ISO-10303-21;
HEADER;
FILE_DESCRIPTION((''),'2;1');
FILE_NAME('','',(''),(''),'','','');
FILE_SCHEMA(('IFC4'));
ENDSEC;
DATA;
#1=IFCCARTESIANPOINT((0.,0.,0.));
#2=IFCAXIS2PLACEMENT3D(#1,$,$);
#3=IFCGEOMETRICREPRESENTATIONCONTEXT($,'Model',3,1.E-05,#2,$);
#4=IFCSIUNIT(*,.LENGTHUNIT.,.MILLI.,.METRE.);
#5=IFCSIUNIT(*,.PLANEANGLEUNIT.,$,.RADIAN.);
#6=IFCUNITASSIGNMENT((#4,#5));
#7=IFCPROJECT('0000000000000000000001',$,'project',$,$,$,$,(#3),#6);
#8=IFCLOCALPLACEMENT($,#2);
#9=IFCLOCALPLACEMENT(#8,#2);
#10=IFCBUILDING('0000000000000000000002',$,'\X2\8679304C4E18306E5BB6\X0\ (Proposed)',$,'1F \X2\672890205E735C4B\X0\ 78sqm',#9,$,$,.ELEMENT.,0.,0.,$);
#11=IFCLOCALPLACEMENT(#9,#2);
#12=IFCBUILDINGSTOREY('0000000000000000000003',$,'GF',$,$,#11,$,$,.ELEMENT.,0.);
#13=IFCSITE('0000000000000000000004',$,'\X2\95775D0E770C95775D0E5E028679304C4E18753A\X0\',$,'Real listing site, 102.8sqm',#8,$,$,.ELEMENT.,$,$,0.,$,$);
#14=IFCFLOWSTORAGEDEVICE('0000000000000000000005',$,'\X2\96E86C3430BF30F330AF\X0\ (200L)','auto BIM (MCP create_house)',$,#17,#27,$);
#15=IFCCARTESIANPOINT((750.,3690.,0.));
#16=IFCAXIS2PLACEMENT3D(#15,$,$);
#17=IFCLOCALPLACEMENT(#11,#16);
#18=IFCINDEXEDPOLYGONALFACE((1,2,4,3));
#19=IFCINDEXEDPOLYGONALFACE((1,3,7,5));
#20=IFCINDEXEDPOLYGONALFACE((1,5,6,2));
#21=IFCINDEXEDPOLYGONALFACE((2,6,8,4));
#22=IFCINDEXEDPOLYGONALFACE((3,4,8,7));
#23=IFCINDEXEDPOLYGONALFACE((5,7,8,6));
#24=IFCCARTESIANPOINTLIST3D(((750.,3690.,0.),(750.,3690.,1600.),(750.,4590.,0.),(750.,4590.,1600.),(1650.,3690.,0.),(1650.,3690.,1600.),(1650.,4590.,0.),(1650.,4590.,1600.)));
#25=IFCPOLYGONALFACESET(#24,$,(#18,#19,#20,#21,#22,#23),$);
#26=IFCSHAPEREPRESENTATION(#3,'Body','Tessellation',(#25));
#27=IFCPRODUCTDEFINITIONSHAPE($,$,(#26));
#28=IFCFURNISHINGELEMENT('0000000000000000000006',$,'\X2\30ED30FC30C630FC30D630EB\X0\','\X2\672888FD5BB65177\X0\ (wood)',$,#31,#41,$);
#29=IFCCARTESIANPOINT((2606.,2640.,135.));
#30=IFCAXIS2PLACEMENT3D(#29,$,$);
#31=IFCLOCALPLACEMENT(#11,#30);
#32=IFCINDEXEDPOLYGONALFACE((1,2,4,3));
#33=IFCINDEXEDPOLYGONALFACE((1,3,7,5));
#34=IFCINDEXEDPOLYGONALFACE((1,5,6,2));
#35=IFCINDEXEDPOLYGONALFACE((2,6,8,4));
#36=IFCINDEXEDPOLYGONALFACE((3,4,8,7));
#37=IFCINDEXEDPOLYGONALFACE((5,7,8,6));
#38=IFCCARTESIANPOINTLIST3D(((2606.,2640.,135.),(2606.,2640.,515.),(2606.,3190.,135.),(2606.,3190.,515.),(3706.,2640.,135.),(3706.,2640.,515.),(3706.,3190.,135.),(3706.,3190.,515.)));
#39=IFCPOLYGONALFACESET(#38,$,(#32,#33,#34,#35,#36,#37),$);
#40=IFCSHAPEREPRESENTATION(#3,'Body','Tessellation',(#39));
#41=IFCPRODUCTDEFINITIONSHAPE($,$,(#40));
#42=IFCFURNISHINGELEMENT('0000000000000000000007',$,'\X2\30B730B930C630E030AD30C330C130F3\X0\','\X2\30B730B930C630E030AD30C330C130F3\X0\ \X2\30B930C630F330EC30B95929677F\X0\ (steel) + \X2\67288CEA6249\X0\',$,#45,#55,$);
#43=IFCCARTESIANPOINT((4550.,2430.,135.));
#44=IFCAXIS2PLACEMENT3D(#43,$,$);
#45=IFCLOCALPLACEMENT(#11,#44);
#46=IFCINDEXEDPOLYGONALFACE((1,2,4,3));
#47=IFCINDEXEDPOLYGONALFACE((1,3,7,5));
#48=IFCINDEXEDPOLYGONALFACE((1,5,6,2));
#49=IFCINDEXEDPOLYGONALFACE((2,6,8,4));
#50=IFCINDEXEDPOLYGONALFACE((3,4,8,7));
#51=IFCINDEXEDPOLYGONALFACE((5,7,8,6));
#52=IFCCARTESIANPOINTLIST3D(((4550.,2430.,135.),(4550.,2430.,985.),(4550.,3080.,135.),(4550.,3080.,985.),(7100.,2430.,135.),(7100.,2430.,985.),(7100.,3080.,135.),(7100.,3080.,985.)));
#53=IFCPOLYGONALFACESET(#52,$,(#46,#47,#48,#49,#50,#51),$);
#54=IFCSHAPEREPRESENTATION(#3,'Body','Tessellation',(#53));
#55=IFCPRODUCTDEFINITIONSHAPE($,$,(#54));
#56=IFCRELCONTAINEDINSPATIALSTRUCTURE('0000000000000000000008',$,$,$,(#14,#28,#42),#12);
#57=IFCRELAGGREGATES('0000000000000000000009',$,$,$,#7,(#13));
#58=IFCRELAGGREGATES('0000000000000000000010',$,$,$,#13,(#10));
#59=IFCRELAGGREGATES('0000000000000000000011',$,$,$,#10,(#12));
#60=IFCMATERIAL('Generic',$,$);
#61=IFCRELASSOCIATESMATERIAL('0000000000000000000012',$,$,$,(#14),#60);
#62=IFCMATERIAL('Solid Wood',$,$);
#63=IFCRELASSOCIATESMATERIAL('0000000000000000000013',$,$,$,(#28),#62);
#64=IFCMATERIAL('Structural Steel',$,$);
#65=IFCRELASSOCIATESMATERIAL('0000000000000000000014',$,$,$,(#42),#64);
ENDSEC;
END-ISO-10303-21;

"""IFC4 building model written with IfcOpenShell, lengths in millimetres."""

from ifc_helpers import new_model, si_unit, frame, frame_2d, origin, place, context, project, spatial, rectangle, extrude, material, element, save


model = new_model("IFC4")

# Units and contexts
model_context = context("Model", 3, precision=1e-05, world=origin())
ifc_project = project(units=[si_unit("LENGTHUNIT", "METRE", prefix="MILLI"), si_unit("PLANEANGLEUNIT", "RADIAN")], contexts=[model_context])

# Site, building, storey
site_placement = place(None, origin())
site = spatial("IfcSite", under=ifc_project, at=site_placement, Name="長崎県長崎市虹が丘町", ObjectType="Real listing site, 102.8sqm", CompositionType="ELEMENT", RefElevation=0.0)
building_placement = place(site_placement, origin())
building = spatial("IfcBuilding", under=site, at=building_placement, Name="虹が丘の家 (Proposed)", ObjectType="1F 木造平屋 78sqm", CompositionType="ELEMENT", ElevationOfRefHeight=0.0, ElevationOfTerrain=0.0)
storey_placement = place(building_placement, origin())
storey = spatial("IfcBuildingStorey", under=building, at=storey_placement, Name="GF", CompositionType="ELEMENT", Elevation=0.0)

# Shared definitions
ifc_material_1 = material(Name="Solid Wood")

# Shared definitions
ifc_material_2 = material(Name="Generic")

# Flow storage device
flow_storage_device_placement = place(storey_placement, frame((750.0, 3690.0, 0.0)))
element("IfcFlowStorageDevice", 1, at=flow_storage_device_placement, inside=storey, material=ifc_material_2, Name="雨水タンク (200L)", Description="auto BIM (MCP create_house)", context=model_context, shape_type="SweptSolid", body=[
    extrude(rectangle(XDim=900.0, YDim=900.0, at=frame_2d((450.0, 450.0))), frame((750.0, 3690.0, 0.0)), (0.0, 0.0, 1.0), 1600.0),
])

# Furnishing elements
furnishing_1_placement = place(storey_placement, frame((2606.0, 2640.0, 135.0)))
element("IfcFurnishingElement", 2, at=furnishing_1_placement, inside=storey, material=ifc_material_1, Name="ローテーブル", Description="木製家具 (wood)", context=model_context, shape_type="SweptSolid", body=[
    extrude(rectangle(XDim=1100.0, YDim=550.0, at=frame_2d((550.0, 275.0))), frame((2606.0, 2640.0, 135.0)), (0.0, 0.0, 1.0), 380.0),
])
ifc_material_3 = material(Name="Structural Steel")
furnishing_2_placement = place(storey_placement, frame((4550.0, 2430.0, 135.0)))
element("IfcFurnishingElement", 3, at=furnishing_2_placement, inside=storey, material=ifc_material_3, Name="システムキッチン", Description="システムキッチン ステンレス天板 (steel) + 木質扉", context=model_context, shape_type="SweptSolid", body=[
    extrude(rectangle(XDim=2550.0, YDim=650.0, at=frame_2d((1275.0, 325.0))), frame((4550.0, 2430.0, 135.0)), (0.0, 0.0, 1.0), 850.0),
])

save(model, "model.ifc")
